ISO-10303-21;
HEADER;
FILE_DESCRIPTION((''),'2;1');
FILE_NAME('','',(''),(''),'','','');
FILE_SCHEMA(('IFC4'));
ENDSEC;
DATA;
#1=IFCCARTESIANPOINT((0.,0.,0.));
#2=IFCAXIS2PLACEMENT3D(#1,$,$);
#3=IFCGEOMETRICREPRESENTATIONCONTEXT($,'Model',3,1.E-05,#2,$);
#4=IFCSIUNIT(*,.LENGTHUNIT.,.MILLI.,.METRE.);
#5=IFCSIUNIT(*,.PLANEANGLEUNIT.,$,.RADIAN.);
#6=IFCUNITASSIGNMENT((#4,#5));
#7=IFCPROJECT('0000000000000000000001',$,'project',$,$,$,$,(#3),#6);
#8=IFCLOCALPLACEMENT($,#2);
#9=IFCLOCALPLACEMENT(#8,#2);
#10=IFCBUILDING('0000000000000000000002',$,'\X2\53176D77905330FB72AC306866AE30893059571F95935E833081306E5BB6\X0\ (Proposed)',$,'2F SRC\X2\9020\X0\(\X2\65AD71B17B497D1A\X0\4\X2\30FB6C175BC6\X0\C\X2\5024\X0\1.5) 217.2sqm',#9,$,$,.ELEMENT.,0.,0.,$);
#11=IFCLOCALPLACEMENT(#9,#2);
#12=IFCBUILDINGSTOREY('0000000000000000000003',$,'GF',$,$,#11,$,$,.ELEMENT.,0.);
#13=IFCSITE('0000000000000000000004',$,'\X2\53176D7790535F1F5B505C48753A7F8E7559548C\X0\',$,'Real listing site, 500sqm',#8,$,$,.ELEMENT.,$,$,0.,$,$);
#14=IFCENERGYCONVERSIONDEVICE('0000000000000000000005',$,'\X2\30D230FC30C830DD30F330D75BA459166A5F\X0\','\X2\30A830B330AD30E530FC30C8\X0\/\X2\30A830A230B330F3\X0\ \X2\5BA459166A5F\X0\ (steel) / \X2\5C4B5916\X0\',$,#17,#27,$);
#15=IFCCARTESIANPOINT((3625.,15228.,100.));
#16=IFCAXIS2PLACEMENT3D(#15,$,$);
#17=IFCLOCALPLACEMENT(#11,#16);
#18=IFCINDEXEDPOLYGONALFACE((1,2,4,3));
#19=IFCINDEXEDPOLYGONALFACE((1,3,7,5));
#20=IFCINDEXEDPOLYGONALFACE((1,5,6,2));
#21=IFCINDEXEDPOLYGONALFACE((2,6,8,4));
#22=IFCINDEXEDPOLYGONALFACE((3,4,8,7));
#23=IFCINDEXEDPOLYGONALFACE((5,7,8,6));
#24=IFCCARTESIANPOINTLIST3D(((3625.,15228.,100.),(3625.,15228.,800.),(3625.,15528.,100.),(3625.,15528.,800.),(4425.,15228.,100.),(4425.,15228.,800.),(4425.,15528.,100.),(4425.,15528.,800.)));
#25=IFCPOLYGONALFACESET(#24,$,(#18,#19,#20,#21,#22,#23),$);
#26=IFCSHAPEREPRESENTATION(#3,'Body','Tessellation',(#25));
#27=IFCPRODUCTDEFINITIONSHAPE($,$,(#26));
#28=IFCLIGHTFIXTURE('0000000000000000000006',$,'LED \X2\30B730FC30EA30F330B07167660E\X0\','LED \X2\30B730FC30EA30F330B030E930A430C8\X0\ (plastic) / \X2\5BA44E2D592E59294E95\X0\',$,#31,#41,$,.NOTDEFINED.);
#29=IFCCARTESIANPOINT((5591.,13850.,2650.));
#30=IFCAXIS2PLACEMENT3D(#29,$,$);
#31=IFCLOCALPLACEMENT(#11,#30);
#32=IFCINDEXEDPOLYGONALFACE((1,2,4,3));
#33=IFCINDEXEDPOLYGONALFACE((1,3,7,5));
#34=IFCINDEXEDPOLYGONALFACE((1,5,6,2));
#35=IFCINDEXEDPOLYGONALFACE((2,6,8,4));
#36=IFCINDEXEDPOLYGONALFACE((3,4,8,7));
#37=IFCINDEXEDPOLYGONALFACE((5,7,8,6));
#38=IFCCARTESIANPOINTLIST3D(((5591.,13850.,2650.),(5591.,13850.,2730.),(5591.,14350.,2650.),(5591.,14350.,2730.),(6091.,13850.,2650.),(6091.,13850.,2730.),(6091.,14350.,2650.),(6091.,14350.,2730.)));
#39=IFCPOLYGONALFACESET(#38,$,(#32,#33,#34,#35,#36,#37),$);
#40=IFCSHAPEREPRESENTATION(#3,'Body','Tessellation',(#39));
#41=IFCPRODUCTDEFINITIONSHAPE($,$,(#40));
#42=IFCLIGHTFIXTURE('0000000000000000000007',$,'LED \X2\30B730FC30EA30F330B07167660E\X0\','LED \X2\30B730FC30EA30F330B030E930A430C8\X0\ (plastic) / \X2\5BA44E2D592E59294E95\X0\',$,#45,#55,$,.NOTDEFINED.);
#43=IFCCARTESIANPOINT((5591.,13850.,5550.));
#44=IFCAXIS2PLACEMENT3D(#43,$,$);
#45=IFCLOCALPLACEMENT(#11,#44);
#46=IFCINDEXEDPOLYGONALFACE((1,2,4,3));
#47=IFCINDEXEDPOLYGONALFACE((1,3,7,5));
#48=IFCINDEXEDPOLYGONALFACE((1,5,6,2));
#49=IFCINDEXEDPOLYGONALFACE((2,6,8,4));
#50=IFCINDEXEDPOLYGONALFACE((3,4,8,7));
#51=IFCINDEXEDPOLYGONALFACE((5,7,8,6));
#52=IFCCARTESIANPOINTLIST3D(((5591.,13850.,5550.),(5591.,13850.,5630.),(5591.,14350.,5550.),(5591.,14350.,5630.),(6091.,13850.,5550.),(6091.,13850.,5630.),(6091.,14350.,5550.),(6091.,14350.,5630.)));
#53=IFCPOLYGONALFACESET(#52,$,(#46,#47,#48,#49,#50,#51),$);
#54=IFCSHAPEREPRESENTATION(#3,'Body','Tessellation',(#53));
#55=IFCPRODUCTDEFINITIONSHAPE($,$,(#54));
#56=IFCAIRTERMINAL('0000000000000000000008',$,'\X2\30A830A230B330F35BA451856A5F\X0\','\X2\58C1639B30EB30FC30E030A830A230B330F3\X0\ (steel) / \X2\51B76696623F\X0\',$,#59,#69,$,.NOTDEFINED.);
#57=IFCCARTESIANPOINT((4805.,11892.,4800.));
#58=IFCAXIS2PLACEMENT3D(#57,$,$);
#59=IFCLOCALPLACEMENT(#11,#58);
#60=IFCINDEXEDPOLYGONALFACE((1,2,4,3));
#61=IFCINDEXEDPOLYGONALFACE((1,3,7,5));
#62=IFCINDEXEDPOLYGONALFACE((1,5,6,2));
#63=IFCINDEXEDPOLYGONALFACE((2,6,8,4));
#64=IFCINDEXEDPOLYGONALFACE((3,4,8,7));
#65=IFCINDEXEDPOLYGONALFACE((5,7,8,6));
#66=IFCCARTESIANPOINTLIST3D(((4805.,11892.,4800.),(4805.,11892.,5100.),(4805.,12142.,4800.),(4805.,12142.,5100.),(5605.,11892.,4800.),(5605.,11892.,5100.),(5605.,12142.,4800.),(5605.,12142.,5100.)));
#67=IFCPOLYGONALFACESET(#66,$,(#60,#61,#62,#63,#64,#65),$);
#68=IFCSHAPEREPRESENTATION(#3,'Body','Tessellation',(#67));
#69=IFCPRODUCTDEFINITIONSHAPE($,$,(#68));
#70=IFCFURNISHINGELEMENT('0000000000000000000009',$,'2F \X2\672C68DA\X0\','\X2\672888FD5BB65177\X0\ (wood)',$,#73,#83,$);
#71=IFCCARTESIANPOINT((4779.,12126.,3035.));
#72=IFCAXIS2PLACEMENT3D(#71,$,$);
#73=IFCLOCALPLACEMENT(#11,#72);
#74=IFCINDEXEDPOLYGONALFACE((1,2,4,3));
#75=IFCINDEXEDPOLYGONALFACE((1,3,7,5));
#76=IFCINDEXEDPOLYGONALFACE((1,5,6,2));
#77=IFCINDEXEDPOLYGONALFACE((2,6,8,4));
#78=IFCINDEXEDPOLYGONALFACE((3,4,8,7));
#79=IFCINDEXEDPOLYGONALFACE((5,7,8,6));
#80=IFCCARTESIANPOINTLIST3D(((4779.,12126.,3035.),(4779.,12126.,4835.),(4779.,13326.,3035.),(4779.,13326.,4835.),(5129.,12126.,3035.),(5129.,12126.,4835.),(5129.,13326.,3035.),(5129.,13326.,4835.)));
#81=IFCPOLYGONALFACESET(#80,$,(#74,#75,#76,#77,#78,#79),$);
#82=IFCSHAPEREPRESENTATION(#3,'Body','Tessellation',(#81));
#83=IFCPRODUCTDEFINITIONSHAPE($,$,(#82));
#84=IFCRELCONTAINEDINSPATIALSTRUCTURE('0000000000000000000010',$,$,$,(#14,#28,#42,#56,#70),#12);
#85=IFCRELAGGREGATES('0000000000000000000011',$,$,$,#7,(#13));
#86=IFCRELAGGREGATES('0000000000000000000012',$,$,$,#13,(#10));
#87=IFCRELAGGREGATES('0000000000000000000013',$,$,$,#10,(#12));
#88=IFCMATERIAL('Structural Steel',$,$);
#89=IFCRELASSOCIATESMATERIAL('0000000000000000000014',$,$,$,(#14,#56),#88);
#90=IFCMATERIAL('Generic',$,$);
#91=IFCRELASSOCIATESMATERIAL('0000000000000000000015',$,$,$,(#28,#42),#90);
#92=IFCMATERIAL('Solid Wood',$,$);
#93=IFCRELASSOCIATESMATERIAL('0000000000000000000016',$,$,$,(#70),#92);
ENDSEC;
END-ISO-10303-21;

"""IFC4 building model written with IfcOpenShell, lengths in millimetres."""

from ifc_helpers import new_model, si_unit, frame, frame_2d, origin, place, context, project, spatial, rectangle, extrude, material, element, save


model = new_model("IFC4")

# Units and contexts
model_context = context("Model", 3, precision=1e-05, world=origin())
ifc_project = project(units=[si_unit("LENGTHUNIT", "METRE", prefix="MILLI"), si_unit("PLANEANGLEUNIT", "RADIAN")], contexts=[model_context])

# Site, building, storey
site_placement = place(None, origin())
site = spatial("IfcSite", under=ifc_project, at=site_placement, Name="北海道弟子屈町美留和", ObjectType="Real listing site, 500sqm", CompositionType="ELEMENT", RefElevation=0.0)
building_placement = place(site_placement, origin())
building = spatial("IfcBuilding", under=site, at=building_placement, Name="北海道・犬と暮らす土間広めの家 (Proposed)", ObjectType="2F SRC造(断熱等級4・気密C値1.5) 217.2sqm", CompositionType="ELEMENT", ElevationOfRefHeight=0.0, ElevationOfTerrain=0.0)
storey_placement = place(building_placement, origin())
storey = spatial("IfcBuildingStorey", under=building, at=storey_placement, Name="GF", CompositionType="ELEMENT", Elevation=0.0)

# Shared definitions
ifc_material_1 = material(Name="Solid Wood")

# Shared definitions
ifc_material_2 = material(Name="Structural Steel")

# Shared definitions
ifc_material_3 = material(Name="Generic")

# Energy conversion device
energy_conversion_device_placement = place(storey_placement, frame((3625.0, 15228.0, 100.0)))
element("IfcEnergyConversionDevice", 1, at=energy_conversion_device_placement, inside=storey, material=ifc_material_2, Name="ヒートポンプ室外機", Description="エコキュート/エアコン 室外機 (steel) / 屋外", context=model_context, shape_type="SweptSolid", body=[
    extrude(rectangle(XDim=800.0, YDim=300.0, at=frame_2d((400.0, 150.0))), frame((3625.0, 15228.0, 100.0)), (0.0, 0.0, 1.0), 700.0),
])

# Light fixtures
light_fixture_1_placement = place(storey_placement, frame((5591.0, 13850.0, 2650.0)))
element("IfcLightFixture", 2, at=light_fixture_1_placement, inside=storey, material=ifc_material_3, Name="LED シーリング照明", Description="LED シーリングライト (plastic) / 室中央天井", PredefinedType="NOTDEFINED", context=model_context, shape_type="SweptSolid", body=[
    extrude(rectangle(XDim=500.0, YDim=500.0, at=frame_2d((250.0, 250.0))), frame((5591.0, 13850.0, 2650.0)), (0.0, 0.0, 1.0), 80.0),
])
light_fixture_2_placement = place(storey_placement, frame((5591.0, 13850.0, 5550.0)))
element("IfcLightFixture", 3, at=light_fixture_2_placement, inside=storey, material=ifc_material_3, Name="LED シーリング照明", Description="LED シーリングライト (plastic) / 室中央天井", PredefinedType="NOTDEFINED", context=model_context, shape_type="SweptSolid", body=[
    extrude(rectangle(XDim=500.0, YDim=500.0, at=frame_2d((250.0, 250.0))), frame((5591.0, 13850.0, 5550.0)), (0.0, 0.0, 1.0), 80.0),
])

# Air terminal
air_terminal_placement = place(storey_placement, frame((4805.0, 11892.0, 4800.0)))
element("IfcAirTerminal", 4, at=air_terminal_placement, inside=storey, material=ifc_material_2, Name="エアコン室内機", Description="壁掛ルームエアコン (steel) / 冷暖房", PredefinedType="NOTDEFINED", context=model_context, shape_type="SweptSolid", body=[
    extrude(rectangle(XDim=800.0, YDim=250.0, at=frame_2d((400.0, 125.0))), frame((4805.0, 11892.0, 4800.0)), (0.0, 0.0, 1.0), 300.0),
])

# Furnishing element
furnishing_placement = place(storey_placement, frame((4779.0, 12126.0, 3035.0)))
element("IfcFurnishingElement", 5, at=furnishing_placement, inside=storey, material=ifc_material_1, Name="2F 本棚", Description="木製家具 (wood)", context=model_context, shape_type="SweptSolid", body=[
    extrude(rectangle(XDim=350.0, YDim=1200.0, at=frame_2d((175.0, 600.0))), frame((4779.0, 12126.0, 3035.0)), (0.0, 0.0, 1.0), 1800.0),
])

save(model, "model.ifc")
